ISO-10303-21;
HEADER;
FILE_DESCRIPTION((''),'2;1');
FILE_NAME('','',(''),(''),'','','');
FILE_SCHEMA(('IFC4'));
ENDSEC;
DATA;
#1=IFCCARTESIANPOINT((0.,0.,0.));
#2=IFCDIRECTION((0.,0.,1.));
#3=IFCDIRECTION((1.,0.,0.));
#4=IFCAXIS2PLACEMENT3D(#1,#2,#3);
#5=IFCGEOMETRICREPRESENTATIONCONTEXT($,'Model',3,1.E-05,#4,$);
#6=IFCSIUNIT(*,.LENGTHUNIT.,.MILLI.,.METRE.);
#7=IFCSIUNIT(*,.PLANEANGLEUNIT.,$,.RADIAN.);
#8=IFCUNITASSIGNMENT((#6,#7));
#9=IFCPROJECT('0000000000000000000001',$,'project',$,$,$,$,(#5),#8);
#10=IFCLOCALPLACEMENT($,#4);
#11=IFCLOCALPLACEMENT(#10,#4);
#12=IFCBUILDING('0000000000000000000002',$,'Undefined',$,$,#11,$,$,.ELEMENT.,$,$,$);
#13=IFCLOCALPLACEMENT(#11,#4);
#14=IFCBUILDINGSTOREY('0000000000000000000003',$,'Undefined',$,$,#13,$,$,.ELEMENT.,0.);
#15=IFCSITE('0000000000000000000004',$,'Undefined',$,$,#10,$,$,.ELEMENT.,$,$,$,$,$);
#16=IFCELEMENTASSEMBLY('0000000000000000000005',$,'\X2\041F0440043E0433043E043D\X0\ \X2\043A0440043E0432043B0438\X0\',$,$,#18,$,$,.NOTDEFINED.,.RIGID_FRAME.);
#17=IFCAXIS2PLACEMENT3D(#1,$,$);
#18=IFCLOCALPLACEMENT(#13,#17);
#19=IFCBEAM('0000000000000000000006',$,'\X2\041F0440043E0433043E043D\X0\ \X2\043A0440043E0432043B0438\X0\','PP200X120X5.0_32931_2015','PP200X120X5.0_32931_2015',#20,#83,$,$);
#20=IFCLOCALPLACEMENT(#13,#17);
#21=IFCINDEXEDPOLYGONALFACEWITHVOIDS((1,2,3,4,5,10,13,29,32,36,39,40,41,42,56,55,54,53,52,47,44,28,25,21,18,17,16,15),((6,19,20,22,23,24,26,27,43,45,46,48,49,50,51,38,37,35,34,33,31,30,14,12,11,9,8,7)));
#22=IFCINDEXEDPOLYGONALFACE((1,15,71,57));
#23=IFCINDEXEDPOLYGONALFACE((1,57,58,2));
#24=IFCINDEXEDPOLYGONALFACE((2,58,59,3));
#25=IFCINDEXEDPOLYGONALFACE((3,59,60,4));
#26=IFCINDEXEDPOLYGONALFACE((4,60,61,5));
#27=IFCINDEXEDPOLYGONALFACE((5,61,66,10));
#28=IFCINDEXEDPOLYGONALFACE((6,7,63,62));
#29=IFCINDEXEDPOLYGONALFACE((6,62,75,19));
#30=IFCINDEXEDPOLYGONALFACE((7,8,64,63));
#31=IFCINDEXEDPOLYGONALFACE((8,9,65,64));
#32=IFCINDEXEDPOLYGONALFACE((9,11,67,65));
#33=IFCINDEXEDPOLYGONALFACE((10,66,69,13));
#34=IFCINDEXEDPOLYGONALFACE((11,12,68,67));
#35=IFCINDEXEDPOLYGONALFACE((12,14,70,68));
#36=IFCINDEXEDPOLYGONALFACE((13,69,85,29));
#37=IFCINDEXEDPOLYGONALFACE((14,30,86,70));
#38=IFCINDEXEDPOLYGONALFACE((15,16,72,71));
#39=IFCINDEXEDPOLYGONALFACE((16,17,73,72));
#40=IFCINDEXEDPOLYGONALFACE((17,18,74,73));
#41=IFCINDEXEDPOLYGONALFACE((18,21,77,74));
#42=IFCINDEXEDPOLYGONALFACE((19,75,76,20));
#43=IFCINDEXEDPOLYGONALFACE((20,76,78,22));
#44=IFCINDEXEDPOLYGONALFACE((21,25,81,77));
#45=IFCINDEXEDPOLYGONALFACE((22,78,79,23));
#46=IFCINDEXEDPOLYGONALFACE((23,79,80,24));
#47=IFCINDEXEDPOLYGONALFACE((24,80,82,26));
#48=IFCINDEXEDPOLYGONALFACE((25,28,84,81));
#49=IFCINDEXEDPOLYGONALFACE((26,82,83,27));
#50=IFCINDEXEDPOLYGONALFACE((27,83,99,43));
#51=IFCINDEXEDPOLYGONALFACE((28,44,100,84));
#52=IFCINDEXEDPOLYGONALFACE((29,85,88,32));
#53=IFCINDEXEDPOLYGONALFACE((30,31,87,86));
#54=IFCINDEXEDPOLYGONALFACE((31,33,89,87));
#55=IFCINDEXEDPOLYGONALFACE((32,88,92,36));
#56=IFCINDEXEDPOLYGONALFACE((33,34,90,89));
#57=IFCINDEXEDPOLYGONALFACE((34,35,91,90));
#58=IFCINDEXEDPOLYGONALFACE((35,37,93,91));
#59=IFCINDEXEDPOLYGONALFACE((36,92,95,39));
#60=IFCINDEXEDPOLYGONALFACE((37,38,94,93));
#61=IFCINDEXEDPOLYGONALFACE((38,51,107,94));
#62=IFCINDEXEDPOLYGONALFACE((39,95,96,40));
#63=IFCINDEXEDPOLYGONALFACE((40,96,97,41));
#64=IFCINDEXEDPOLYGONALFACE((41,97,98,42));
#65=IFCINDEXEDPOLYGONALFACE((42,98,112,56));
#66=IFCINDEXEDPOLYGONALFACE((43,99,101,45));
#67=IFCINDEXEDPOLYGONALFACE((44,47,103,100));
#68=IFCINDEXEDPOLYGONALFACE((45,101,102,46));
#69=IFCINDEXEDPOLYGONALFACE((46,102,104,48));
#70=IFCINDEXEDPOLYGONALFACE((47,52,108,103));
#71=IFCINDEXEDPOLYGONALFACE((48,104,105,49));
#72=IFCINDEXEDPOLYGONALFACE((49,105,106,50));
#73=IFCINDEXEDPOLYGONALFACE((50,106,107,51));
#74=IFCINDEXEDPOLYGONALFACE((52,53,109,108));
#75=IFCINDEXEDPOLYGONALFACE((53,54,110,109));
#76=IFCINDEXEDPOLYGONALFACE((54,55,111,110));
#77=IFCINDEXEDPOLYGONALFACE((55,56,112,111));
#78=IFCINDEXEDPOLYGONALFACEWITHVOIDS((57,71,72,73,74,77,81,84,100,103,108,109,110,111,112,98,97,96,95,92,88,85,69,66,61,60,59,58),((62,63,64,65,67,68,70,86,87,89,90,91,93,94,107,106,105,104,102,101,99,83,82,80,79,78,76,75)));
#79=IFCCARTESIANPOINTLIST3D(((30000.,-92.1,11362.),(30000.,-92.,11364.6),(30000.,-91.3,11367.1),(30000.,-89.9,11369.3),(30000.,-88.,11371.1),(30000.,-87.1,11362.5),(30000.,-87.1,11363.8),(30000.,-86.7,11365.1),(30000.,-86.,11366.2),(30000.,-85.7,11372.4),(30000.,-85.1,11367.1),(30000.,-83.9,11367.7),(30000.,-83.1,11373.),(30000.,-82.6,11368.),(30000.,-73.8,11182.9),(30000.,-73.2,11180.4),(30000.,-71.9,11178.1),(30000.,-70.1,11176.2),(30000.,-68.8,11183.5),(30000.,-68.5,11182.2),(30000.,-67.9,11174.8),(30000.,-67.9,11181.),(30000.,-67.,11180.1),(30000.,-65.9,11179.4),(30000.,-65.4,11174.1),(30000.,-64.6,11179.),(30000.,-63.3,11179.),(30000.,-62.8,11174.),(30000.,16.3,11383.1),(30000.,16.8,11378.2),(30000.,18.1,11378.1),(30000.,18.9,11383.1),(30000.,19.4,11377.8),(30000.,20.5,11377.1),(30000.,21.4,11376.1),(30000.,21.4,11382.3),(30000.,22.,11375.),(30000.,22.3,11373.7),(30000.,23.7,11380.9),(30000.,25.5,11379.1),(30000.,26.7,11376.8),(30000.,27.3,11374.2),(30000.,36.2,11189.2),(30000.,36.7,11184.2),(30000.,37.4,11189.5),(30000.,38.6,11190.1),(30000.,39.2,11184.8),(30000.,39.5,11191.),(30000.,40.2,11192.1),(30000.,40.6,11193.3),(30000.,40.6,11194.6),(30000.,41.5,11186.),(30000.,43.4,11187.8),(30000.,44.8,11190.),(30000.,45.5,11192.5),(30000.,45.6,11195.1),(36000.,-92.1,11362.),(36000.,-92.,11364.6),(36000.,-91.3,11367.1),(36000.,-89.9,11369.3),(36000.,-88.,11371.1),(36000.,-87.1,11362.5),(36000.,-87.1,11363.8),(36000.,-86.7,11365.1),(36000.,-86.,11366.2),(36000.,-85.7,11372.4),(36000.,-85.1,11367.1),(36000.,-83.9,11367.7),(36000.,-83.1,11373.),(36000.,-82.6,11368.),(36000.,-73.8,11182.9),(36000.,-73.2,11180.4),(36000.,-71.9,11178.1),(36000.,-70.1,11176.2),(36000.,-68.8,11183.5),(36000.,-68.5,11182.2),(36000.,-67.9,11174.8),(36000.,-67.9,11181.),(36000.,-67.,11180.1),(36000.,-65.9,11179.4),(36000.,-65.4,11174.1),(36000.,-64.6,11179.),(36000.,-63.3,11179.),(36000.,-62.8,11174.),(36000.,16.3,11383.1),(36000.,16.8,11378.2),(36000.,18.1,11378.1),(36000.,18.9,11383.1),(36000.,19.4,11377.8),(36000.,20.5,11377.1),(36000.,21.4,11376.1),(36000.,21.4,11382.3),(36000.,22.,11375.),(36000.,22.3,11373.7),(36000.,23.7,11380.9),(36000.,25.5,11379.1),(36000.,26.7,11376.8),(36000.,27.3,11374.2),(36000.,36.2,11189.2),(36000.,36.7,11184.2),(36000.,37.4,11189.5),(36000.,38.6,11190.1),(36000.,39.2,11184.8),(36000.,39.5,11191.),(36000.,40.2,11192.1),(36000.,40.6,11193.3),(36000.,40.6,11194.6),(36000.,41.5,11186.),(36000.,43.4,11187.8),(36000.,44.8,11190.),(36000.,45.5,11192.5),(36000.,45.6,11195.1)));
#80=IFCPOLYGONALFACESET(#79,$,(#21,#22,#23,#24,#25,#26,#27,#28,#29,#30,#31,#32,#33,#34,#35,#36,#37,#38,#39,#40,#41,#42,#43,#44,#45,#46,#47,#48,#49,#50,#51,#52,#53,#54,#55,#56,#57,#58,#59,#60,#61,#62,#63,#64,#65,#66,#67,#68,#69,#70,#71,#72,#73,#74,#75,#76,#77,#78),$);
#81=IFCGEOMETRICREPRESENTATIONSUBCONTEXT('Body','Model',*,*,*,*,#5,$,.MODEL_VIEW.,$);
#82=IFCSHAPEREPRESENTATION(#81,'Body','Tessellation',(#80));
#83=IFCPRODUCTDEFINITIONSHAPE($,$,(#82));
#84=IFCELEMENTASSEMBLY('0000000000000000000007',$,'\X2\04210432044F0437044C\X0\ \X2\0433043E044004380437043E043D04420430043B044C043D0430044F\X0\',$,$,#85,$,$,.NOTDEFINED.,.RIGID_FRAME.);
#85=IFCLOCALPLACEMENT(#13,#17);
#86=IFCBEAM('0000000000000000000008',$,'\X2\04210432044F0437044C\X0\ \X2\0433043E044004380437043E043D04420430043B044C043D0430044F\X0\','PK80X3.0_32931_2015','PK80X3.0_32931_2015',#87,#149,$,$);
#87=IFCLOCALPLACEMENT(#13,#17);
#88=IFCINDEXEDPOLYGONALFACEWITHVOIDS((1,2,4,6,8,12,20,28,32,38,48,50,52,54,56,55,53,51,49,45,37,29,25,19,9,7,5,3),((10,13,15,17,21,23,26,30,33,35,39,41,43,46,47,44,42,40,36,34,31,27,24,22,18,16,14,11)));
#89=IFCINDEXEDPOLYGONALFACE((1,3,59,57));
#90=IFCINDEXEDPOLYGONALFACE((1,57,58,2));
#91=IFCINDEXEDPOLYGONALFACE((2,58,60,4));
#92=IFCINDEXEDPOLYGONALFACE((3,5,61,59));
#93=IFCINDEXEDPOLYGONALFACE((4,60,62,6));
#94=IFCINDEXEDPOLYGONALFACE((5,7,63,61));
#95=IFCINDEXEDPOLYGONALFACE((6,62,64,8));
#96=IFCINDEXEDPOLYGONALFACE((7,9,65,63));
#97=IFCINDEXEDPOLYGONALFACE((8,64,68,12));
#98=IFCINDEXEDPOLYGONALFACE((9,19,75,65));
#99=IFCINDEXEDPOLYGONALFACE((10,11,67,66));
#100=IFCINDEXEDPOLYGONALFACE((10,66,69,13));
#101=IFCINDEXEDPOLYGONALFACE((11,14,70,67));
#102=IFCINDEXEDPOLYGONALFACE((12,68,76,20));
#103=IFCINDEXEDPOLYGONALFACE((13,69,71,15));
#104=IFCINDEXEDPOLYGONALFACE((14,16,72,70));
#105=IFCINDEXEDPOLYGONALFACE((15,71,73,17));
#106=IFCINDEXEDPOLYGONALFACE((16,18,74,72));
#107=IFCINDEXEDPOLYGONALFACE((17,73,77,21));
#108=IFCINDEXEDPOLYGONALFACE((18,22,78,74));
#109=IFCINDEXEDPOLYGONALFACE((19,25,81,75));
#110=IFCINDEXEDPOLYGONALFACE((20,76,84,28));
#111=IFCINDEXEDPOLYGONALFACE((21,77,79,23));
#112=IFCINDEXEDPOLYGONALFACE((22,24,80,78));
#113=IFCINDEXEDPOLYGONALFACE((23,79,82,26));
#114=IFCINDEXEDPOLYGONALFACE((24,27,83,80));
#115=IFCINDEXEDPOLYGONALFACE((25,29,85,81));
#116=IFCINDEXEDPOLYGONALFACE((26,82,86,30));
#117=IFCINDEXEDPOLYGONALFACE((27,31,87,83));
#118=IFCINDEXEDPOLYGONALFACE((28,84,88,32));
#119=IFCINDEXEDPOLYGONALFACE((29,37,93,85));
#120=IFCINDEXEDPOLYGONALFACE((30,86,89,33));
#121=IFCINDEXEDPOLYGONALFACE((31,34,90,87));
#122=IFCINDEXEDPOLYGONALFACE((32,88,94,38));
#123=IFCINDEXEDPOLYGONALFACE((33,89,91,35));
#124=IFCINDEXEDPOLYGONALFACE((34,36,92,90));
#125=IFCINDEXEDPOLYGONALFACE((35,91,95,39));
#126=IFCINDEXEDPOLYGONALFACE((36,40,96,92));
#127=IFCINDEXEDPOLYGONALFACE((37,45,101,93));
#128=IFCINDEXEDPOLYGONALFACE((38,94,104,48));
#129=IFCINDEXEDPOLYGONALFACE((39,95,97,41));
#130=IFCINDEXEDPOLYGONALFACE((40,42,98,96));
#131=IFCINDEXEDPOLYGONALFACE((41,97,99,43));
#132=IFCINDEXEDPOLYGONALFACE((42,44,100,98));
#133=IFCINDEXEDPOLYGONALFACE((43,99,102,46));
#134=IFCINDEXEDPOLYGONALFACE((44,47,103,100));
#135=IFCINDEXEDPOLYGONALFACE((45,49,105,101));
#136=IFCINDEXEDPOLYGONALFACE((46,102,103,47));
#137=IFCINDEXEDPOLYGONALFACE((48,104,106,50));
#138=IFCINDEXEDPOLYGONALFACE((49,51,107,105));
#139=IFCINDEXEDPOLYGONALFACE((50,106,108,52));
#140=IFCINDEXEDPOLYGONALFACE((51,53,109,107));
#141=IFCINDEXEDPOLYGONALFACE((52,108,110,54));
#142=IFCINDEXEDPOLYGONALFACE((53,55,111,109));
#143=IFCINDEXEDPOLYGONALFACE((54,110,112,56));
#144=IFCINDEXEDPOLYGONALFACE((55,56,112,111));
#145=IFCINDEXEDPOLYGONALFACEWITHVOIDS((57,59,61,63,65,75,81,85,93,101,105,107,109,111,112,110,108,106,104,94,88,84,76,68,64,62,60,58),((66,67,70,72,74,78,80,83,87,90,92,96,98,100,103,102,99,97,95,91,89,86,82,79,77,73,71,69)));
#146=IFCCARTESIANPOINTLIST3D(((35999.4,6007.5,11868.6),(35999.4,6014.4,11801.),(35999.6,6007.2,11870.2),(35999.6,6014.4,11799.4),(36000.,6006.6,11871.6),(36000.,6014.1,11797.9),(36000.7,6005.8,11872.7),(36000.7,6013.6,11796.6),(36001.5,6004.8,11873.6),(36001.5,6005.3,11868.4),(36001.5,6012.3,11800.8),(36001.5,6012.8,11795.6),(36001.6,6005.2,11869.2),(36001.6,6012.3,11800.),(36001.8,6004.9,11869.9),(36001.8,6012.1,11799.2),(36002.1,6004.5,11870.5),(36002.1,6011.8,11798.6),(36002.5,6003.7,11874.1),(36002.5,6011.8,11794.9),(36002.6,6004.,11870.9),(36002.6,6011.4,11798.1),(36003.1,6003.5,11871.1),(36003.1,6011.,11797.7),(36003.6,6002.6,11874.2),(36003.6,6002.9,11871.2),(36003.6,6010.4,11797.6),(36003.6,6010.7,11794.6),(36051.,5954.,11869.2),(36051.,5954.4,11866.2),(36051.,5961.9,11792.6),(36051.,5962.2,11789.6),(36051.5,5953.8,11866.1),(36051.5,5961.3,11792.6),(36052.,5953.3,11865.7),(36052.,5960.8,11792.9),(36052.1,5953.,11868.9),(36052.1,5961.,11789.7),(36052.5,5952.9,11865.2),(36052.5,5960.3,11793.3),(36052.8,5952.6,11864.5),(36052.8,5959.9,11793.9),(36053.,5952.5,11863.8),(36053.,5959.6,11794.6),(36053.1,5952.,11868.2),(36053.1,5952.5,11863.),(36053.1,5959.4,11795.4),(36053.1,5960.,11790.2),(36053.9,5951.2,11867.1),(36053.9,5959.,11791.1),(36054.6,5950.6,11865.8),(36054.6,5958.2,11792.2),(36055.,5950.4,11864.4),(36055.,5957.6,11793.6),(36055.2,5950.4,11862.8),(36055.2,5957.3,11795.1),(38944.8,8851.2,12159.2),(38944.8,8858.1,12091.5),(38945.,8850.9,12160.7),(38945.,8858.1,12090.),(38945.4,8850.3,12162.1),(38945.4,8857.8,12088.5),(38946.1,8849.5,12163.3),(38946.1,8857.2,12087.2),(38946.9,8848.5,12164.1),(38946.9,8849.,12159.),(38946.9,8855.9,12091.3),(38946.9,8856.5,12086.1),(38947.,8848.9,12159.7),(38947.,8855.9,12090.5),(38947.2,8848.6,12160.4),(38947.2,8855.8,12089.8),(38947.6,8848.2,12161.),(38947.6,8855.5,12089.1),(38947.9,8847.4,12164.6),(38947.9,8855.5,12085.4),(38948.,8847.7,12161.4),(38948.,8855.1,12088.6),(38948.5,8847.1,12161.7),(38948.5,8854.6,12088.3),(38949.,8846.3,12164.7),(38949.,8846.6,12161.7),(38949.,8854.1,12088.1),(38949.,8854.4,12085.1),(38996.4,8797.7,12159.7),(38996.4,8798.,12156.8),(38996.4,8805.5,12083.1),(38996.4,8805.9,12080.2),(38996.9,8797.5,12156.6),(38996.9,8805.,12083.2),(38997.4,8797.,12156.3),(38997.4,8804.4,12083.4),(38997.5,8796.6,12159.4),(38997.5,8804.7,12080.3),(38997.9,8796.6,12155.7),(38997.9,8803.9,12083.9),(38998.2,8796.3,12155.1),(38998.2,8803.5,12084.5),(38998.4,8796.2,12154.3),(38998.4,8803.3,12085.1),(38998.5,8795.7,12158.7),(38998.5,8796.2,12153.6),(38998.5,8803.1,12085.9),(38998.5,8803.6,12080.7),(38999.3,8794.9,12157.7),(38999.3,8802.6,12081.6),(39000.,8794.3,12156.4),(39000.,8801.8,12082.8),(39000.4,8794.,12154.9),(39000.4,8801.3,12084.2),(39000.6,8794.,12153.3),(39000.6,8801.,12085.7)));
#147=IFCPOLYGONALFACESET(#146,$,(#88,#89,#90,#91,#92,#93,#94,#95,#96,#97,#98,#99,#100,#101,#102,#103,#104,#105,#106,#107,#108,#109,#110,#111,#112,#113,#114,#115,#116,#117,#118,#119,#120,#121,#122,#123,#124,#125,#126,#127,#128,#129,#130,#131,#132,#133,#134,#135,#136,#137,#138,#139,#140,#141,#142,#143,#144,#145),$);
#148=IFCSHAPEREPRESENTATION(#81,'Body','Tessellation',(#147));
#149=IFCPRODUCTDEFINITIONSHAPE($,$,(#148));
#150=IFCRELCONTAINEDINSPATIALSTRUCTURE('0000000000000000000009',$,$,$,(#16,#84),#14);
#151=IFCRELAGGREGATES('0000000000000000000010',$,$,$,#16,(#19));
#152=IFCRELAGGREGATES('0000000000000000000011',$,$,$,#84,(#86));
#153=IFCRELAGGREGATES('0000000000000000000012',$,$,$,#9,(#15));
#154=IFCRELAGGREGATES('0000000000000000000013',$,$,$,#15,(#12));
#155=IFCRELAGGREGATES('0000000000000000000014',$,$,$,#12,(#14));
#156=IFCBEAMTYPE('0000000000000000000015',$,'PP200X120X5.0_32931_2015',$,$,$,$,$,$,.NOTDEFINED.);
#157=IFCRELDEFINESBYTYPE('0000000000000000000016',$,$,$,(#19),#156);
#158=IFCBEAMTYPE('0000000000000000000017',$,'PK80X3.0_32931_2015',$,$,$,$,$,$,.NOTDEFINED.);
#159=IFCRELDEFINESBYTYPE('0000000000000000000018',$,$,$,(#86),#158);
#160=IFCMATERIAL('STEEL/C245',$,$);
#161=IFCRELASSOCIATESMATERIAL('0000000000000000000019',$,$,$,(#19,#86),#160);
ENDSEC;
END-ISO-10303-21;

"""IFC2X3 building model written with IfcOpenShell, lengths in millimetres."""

from ifc_helpers import new_model, si_unit, frame, origin_with_axes, origin_2d_with_axis, place, context, subcontext, project, spatial, hollow_rectangle, extrude, material, type_object, element, aggregate, save


model = new_model("IFC2X3")

# Units and contexts
model_context = context("Model", 3, precision=1e-05, world=origin_with_axes())
body_context = subcontext(model_context, "Body", "Model", "MODEL_VIEW")
ifc_project = project(units=[si_unit("LENGTHUNIT", "METRE", prefix="MILLI"), si_unit("PLANEANGLEUNIT", "RADIAN")], contexts=[model_context])

# Site, building, storey
site_placement = place(None, origin_with_axes())
site = spatial("IfcSite", under=ifc_project, at=site_placement, Name="Undefined", CompositionType="ELEMENT")
building_placement = place(site_placement, origin_with_axes())
building = spatial("IfcBuilding", under=site, at=building_placement, Name="Undefined", CompositionType="ELEMENT")
storey_placement = place(building_placement, origin_with_axes())
storey = spatial("IfcBuildingStorey", under=building, at=storey_placement, Name="Undefined", CompositionType="ELEMENT", Elevation=0.0)

# Shared definitions
ifc_material_1 = material(Name="STEEL/C245")

# Element assemblies, beams
assembly_1_placement = place(storey_placement, origin_with_axes())
assembly_1 = element("IfcElementAssembly", 1, at=assembly_1_placement, inside=storey, Name="Прогон кровли", AssemblyPlace="NOTDEFINED", PredefinedType="RIGID_FRAME")
beam_type_1 = type_object("IfcBeamType", Name="PP200X120X5.0_32931_2015", PredefinedType="NOTDEFINED")
beam_1_placement = place(assembly_1_placement, frame((36000.0, -23.2, 11278.6), z_axis=(0.0, -0.101645, 0.994821), x_axis=(-1.0, 0.0, 0.0)))
beam_1 = element("IfcBeam", 2, at=beam_1_placement, type_object=beam_type_1, material=ifc_material_1, Name="Прогон кровли", Description="PP200X120X5.0_32931_2015", ObjectType="PP200X120X5.0_32931_2015", context=body_context, shape_type="SweptSolid", body=[
    extrude(hollow_rectangle(XDim=120.0, YDim=200.0, WallThickness=5.0, InnerFilletRadius=5.0, OuterFilletRadius=10.0, at=origin_2d_with_axis()), frame((6000.0, 0.0, 0.0), z_axis=(-1.0, 0.0, 0.0), x_axis=(0.0, -1.0, 0.0)), (0.0, 0.0, 1.0), 6000.0),
])
aggregate(assembly_1, [beam_1])
assembly_2_placement = place(storey_placement, origin_with_axes())
assembly_2 = element("IfcElementAssembly", 3, at=assembly_2_placement, inside=storey, Name="Связь горизонтальная", AssemblyPlace="NOTDEFINED", PredefinedType="RIGID_FRAME")
beam_type_2 = type_object("IfcBeamType", Name="PK80X3.0_32931_2015", PredefinedType="NOTDEFINED")
beam_2_placement = place(assembly_2_placement, frame((36027.3, 5982.4, 11831.9), z_axis=(0.0, -0.101645, 0.994821), x_axis=(0.717617, 0.69283, 0.070789)))
beam_2 = element("IfcBeam", 4, at=beam_2_placement, type_object=beam_type_2, material=ifc_material_1, Name="Связь горизонтальная", Description="PK80X3.0_32931_2015", ObjectType="PK80X3.0_32931_2015", context=body_context, shape_type="SweptSolid", body=[
    extrude(hollow_rectangle(XDim=80.0, YDim=80.0, WallThickness=3.0, InnerFilletRadius=3.0, OuterFilletRadius=6.0, at=origin_2d_with_axis()), frame((4104.4, 0.0, 0.0), z_axis=(-1.0, 0.0, 0.0), x_axis=(0.0, -1.0, 0.0)), (0.0, 0.0, 1.0), 4104.4),
])
aggregate(assembly_2, [beam_2])

save(model, "model.ifc")
